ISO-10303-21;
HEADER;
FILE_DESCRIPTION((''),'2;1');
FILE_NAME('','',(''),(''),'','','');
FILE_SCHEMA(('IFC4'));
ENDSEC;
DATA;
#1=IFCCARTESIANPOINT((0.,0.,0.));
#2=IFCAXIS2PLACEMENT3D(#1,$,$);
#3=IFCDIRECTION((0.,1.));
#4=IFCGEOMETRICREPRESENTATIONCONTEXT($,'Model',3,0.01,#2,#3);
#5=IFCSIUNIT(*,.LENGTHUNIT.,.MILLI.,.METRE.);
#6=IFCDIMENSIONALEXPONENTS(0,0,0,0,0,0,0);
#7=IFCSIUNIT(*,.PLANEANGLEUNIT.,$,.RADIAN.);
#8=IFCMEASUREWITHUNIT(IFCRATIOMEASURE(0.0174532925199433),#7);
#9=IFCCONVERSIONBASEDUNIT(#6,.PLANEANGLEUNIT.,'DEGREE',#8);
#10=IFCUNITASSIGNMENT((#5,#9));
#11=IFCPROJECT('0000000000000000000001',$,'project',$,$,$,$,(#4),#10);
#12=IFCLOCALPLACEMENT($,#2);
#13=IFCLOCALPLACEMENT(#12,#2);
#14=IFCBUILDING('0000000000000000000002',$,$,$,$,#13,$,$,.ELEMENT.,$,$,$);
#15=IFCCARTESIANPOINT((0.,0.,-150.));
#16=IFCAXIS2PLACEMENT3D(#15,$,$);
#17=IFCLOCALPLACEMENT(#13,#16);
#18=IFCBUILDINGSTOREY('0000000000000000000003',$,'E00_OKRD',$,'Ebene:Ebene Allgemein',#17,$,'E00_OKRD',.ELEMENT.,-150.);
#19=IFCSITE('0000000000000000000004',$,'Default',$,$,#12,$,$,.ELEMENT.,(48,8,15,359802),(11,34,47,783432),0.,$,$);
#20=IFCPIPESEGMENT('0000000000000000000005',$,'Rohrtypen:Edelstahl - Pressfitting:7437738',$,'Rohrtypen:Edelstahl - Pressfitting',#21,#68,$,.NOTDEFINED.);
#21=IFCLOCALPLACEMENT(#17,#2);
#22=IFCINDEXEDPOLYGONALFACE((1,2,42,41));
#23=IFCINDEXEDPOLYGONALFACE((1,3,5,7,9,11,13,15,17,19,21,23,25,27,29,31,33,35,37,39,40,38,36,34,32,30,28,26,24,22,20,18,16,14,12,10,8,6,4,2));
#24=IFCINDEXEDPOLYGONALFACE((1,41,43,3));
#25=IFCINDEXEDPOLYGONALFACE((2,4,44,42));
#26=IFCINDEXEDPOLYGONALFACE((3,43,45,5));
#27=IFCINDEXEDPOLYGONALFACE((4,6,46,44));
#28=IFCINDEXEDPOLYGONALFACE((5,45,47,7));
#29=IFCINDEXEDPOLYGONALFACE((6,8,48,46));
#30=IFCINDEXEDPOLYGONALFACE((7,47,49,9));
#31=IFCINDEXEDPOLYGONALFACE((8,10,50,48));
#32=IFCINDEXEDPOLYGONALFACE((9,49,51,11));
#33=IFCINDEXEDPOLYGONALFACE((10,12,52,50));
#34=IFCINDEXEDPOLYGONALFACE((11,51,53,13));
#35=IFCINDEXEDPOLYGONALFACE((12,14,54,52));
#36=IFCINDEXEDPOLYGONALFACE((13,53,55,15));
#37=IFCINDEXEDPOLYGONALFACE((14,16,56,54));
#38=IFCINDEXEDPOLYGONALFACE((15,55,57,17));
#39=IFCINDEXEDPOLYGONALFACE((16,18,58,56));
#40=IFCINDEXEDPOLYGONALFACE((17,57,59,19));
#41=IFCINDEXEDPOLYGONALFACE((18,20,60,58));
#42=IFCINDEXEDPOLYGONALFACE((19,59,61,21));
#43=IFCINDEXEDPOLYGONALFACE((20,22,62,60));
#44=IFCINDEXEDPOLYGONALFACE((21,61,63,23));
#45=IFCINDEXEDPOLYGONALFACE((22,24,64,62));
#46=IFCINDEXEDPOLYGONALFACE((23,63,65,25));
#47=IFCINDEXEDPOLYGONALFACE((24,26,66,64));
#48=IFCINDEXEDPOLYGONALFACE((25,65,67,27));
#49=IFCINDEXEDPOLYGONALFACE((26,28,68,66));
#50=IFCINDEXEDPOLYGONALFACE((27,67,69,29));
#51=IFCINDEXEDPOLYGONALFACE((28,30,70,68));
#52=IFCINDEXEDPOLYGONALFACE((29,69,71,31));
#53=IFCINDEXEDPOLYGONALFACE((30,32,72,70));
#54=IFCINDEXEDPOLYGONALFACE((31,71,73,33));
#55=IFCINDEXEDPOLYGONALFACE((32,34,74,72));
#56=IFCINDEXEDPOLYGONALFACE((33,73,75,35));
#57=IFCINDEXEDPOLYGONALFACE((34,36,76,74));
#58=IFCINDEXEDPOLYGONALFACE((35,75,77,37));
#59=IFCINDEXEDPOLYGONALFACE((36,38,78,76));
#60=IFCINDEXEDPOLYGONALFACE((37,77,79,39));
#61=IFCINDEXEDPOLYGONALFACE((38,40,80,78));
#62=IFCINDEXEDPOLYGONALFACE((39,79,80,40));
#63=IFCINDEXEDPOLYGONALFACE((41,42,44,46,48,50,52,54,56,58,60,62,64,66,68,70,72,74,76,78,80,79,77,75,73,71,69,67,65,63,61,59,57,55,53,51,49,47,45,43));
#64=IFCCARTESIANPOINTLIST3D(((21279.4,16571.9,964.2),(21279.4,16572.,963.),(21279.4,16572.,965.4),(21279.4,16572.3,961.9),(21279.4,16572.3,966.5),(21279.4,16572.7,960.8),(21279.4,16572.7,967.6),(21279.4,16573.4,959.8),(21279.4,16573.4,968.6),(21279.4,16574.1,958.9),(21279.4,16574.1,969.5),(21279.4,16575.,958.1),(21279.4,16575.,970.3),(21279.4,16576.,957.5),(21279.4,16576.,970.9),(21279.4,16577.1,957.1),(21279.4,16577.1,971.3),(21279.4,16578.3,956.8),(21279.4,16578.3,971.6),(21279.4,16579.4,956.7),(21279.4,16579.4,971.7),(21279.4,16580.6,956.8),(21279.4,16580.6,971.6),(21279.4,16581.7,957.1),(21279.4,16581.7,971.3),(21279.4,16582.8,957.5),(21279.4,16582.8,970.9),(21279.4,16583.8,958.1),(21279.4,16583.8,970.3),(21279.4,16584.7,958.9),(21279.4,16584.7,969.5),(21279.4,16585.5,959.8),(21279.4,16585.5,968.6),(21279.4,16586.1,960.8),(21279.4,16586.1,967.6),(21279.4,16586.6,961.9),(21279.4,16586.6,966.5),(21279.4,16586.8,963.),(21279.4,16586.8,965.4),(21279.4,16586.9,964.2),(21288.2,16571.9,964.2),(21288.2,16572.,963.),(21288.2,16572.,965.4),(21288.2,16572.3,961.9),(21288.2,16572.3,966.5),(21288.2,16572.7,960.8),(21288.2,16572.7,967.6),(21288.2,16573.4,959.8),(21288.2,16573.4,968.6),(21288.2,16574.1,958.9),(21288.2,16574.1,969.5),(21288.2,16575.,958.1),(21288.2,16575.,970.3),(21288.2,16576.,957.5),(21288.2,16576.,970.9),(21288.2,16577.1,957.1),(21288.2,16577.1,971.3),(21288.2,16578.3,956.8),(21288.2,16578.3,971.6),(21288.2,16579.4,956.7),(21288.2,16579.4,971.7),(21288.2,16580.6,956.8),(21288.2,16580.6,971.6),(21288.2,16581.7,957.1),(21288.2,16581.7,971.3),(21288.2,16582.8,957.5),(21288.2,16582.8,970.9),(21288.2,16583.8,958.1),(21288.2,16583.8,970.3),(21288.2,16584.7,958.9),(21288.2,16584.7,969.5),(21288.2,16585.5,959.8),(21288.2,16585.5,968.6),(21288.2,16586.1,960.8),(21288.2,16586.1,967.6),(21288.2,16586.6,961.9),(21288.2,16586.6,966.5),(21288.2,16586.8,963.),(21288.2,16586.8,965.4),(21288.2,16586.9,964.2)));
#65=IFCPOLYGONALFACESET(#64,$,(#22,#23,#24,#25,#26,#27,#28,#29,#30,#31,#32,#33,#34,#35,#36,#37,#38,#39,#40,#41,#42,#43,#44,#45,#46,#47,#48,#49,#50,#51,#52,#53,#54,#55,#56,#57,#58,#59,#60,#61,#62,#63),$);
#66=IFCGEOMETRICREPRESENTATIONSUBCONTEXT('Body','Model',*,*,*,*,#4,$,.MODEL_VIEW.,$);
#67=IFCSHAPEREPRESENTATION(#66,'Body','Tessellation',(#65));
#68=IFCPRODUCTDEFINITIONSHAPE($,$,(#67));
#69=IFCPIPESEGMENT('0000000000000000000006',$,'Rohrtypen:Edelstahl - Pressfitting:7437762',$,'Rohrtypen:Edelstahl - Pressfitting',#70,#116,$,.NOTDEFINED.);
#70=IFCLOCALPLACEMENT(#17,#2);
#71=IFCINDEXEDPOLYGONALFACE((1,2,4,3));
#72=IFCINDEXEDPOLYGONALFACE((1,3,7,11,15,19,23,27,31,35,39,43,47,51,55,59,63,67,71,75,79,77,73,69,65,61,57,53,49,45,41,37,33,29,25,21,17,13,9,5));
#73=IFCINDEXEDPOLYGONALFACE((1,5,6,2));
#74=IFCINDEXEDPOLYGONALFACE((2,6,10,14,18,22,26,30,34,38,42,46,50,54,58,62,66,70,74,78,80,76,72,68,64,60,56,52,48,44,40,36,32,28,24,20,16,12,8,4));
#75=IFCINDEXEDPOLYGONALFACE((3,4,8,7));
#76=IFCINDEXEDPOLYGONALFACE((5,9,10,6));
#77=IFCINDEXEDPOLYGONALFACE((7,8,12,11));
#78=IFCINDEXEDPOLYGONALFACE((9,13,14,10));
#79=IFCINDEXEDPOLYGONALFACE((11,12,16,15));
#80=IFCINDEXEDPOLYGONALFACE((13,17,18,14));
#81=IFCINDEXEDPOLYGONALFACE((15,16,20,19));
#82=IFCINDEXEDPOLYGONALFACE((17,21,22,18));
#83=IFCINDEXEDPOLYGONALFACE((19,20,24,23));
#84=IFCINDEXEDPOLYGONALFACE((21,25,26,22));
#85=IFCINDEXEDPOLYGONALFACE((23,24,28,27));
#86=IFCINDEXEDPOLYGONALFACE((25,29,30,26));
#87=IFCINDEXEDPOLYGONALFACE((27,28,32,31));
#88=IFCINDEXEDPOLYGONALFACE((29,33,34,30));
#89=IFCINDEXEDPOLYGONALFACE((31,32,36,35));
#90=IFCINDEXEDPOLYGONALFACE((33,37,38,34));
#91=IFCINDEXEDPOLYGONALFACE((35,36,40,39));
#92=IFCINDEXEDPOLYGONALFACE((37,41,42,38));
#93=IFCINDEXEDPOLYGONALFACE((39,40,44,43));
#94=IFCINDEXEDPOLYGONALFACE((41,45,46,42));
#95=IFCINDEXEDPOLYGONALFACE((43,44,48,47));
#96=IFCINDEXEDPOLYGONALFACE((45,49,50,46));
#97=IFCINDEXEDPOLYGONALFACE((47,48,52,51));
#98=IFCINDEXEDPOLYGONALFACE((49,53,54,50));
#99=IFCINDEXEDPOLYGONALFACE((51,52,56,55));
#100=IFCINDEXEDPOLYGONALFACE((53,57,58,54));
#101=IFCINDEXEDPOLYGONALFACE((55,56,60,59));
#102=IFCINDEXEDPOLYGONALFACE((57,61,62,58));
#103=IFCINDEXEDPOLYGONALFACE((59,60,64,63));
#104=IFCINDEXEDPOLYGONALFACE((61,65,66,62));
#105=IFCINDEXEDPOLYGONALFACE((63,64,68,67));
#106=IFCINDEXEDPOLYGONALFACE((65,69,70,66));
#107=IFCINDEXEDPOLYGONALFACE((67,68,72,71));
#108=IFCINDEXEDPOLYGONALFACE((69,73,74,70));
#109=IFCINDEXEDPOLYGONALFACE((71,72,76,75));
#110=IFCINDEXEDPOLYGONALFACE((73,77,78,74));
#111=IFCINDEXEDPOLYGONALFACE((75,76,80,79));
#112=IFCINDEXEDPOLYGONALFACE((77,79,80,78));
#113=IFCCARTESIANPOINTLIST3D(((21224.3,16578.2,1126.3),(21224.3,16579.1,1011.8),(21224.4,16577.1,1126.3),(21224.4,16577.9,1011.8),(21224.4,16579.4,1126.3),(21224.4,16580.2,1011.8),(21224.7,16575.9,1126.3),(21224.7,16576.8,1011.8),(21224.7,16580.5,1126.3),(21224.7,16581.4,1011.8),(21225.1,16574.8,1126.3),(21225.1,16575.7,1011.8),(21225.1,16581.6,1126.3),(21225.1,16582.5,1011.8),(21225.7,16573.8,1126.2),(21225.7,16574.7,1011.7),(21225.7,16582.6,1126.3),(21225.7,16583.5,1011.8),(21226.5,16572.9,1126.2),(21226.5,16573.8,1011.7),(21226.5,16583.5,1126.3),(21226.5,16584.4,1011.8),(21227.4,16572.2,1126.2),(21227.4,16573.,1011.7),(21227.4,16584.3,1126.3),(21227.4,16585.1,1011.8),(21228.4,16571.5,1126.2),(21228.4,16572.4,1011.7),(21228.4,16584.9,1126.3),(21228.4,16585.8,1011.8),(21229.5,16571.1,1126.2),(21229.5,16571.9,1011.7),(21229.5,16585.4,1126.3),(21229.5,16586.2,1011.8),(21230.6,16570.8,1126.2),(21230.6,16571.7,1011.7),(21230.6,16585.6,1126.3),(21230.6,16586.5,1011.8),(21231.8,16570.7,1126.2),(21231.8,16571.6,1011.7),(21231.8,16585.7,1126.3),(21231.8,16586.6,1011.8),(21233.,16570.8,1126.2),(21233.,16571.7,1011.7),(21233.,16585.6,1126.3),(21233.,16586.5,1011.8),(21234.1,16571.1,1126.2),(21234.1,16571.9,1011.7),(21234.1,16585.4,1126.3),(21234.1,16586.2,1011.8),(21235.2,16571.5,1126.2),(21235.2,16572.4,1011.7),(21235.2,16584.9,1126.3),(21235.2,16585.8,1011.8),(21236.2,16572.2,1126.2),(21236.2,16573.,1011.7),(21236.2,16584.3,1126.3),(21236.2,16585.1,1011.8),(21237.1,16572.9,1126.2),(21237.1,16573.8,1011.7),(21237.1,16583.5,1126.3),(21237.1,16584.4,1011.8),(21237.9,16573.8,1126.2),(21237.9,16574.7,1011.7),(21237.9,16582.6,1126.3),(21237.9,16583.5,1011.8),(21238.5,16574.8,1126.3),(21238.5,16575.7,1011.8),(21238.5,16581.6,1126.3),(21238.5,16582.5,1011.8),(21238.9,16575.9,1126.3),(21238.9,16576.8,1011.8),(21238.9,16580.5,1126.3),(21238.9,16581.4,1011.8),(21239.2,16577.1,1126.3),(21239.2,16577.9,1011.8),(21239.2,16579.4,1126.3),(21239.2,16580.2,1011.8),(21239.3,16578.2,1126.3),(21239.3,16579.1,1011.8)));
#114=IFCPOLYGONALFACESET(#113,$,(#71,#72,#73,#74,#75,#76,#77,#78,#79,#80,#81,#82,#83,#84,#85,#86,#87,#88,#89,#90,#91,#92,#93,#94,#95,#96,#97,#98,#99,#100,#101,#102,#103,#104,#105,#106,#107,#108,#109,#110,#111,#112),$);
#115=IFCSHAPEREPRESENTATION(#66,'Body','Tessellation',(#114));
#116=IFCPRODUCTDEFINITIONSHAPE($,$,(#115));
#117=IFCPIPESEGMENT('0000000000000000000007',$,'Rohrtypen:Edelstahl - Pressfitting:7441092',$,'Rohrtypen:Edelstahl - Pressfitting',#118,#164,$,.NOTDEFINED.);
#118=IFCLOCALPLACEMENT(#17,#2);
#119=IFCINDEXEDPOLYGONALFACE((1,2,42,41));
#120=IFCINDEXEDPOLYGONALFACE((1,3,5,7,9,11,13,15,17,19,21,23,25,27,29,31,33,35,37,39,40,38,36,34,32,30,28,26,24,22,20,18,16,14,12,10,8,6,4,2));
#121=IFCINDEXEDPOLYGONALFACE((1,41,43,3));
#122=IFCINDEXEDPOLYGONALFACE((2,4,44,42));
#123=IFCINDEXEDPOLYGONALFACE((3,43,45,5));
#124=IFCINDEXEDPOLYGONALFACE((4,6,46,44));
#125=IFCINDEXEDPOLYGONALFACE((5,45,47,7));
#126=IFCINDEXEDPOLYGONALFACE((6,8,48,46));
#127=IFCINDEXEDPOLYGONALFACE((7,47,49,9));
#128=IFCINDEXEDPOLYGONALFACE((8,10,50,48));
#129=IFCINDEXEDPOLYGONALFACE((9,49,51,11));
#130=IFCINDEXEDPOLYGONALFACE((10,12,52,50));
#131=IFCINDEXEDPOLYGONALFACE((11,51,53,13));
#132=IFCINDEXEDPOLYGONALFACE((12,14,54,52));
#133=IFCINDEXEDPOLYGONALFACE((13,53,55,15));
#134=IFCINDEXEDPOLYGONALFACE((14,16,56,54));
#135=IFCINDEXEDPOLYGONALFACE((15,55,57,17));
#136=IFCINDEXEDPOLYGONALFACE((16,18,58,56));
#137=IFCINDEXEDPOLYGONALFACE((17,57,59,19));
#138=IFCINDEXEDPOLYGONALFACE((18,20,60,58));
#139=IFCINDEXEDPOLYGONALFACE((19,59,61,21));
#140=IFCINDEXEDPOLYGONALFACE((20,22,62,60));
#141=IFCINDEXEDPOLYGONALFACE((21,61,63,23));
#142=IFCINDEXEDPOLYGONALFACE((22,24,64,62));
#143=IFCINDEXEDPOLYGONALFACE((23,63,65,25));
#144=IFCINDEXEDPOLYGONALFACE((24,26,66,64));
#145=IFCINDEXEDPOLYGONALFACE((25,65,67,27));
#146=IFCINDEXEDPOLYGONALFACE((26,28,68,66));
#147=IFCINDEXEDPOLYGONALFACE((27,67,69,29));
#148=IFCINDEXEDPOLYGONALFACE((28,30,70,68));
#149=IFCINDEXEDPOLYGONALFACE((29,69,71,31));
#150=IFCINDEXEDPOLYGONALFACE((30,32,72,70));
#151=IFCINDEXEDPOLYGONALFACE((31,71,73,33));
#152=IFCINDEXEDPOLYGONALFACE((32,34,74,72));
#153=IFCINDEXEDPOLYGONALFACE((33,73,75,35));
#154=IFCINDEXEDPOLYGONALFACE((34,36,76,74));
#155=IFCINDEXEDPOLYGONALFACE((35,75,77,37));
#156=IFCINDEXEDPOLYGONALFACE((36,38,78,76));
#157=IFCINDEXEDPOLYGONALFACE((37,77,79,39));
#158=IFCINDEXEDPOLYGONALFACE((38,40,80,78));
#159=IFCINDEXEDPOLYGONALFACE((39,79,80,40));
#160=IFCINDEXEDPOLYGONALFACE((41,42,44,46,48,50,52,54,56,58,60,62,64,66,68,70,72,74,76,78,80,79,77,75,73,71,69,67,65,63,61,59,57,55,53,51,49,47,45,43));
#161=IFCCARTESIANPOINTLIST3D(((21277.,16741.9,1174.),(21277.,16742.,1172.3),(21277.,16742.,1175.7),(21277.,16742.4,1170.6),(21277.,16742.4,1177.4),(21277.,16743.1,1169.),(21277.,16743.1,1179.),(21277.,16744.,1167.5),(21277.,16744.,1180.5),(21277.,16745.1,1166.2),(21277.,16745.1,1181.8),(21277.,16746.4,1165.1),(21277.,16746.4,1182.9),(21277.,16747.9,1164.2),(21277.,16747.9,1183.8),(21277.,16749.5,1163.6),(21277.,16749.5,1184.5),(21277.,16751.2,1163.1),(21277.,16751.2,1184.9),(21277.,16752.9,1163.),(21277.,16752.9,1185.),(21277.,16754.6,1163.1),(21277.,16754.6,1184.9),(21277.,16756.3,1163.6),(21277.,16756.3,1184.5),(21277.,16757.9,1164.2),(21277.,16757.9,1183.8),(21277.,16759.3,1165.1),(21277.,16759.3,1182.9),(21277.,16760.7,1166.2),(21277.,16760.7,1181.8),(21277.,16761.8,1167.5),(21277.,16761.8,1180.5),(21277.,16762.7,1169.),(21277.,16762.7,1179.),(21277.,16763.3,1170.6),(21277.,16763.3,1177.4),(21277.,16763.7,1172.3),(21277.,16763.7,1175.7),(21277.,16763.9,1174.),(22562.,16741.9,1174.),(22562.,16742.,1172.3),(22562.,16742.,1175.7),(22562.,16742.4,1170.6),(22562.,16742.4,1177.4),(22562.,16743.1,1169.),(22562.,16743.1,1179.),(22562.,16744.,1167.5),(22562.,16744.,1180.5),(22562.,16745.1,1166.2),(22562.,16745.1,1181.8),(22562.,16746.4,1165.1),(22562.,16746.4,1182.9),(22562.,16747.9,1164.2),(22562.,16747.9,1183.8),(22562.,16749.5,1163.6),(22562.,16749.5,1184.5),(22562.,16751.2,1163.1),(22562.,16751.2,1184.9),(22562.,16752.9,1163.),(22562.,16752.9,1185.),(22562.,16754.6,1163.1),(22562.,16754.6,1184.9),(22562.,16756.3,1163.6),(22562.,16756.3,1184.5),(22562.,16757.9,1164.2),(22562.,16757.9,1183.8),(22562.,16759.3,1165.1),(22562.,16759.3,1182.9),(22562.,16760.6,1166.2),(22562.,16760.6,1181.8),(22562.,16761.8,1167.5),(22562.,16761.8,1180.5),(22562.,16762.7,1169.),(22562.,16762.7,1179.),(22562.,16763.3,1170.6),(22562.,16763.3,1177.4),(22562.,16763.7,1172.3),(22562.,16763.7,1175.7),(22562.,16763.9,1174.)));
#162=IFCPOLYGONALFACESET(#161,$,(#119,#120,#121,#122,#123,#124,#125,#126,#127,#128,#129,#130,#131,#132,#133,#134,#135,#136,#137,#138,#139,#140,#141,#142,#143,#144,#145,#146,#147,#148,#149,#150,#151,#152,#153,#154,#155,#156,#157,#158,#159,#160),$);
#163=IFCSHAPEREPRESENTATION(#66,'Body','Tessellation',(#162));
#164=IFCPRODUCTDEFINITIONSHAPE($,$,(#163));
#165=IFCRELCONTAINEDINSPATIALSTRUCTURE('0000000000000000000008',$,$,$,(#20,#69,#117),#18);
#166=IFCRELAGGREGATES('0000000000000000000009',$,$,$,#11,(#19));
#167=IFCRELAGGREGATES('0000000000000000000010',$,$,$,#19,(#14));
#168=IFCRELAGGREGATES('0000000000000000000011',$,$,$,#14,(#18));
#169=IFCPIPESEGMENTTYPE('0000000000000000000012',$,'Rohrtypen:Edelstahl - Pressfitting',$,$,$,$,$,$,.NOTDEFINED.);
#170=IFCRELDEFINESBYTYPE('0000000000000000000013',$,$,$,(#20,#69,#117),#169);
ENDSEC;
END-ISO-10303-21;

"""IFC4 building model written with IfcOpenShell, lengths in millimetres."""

from ifc_helpers import new_model, entity, si_unit, converted_unit, direction, frame, origin, place, context, subcontext, project, spatial, indexed_curve, outline, extrude, type_object, element, save


model = new_model("IFC4")

# Units and contexts
model_context = context("Model", 3, precision=0.01, world=origin(), true_north=direction((0.0, 1.0)))
body_context = subcontext(model_context, "Body", "Model", "MODEL_VIEW")
ifc_project = project(units=[si_unit("LENGTHUNIT", "METRE", prefix="MILLI"), converted_unit("PLANEANGLEUNIT", "DEGREE", entity("IfcRatioMeasure", 0.0174532925199433), si_unit("PLANEANGLEUNIT", "RADIAN"), dimensions=[0, 0, 0, 0, 0, 0, 0])], contexts=[model_context])

# Site, building, storey
site_placement = place(None, origin())
site = spatial("IfcSite", under=ifc_project, at=site_placement, Name="Default", CompositionType="ELEMENT", RefLatitude=(48, 8, 15, 359802), RefLongitude=(11, 34, 47, 783432), RefElevation=0.0)
building_placement = place(site_placement, origin())
building = spatial("IfcBuilding", under=site, at=building_placement, CompositionType="ELEMENT")
storey_placement = place(building_placement, frame((0.0, 0.0, -150.0)))
storey = spatial("IfcBuildingStorey", under=building, at=storey_placement, Name="E00_OKRD", ObjectType="Ebene:Ebene Allgemein", LongName="E00_OKRD", CompositionType="ELEMENT", Elevation=-150.0)

# Pipe segments
pipe_segment_type_1 = type_object("IfcPipeSegmentType", Name="Rohrtypen:Edelstahl - Pressfitting", PredefinedType="NOTDEFINED")
pipe_segment_1_placement = place(storey_placement, origin())
element("IfcPipeSegment", 1, at=pipe_segment_1_placement, inside=storey, type_object=pipe_segment_type_1, Name="Rohrtypen:Edelstahl - Pressfitting:7437738", ObjectType="Rohrtypen:Edelstahl - Pressfitting", PredefinedType="NOTDEFINED", context=body_context, shape_type="SweptSolid", body=[
    extrude(outline(indexed_curve([(7.5, 0.0), (7.4, 1.2), (7.1, 2.3), (6.7, 3.4), (6.1, 4.4), (5.3, 5.3), (4.4, 6.1), (3.4, 6.7), (2.3, 7.1), (1.2, 7.4), (0.0, 7.5), (-1.2, 7.4), (-2.3, 7.1), (-3.4, 6.7), (-4.4, 6.1), (-5.3, 5.3), (-6.1, 4.4), (-6.7, 3.4), (-7.1, 2.3), (-7.4, 1.2), (-7.5, 0.0), (-7.4, -1.2), (-7.1, -2.3), (-6.7, -3.4), (-6.1, -4.4), (-5.3, -5.3), (-4.4, -6.1), (-3.4, -6.7), (-2.3, -7.1), (-1.2, -7.4), (0.0, -7.5), (1.2, -7.4), (2.3, -7.1), (3.4, -6.7), (4.4, -6.1), (5.3, -5.3), (6.1, -4.4), (6.7, -3.4), (7.1, -2.3), (7.4, -1.2), (7.5, 0.0)], self_intersect=False)), frame((21279.4, 16579.4, 964.2), z_axis=(1.0, 0.000009, 0.0), x_axis=(-0.000009, 1.0, 0.0)), (0.0, 0.0, 1.0), 8.8),
])
pipe_segment_2_placement = place(storey_placement, origin())
element("IfcPipeSegment", 2, at=pipe_segment_2_placement, inside=storey, type_object=pipe_segment_type_1, Name="Rohrtypen:Edelstahl - Pressfitting:7437762", ObjectType="Rohrtypen:Edelstahl - Pressfitting", PredefinedType="NOTDEFINED", context=body_context, shape_type="SweptSolid", body=[
    extrude(outline(indexed_curve([(7.5, 0.0), (7.4, 1.2), (7.1, 2.3), (6.7, 3.4), (6.1, 4.4), (5.3, 5.3), (4.4, 6.1), (3.4, 6.7), (2.3, 7.1), (1.2, 7.4), (0.0, 7.5), (-1.2, 7.4), (-2.3, 7.1), (-3.4, 6.7), (-4.4, 6.1), (-5.3, 5.3), (-6.1, 4.4), (-6.7, 3.4), (-7.1, 2.3), (-7.4, 1.2), (-7.5, 0.0), (-7.4, -1.2), (-7.1, -2.3), (-6.7, -3.4), (-6.1, -4.4), (-5.3, -5.3), (-4.4, -6.1), (-3.4, -6.7), (-2.3, -7.1), (-1.2, -7.4), (0.0, -7.5), (1.2, -7.4), (2.3, -7.1), (3.4, -6.7), (4.4, -6.1), (5.3, -5.3), (6.1, -4.4), (6.7, -3.4), (7.1, -2.3), (7.4, -1.2), (7.5, 0.0)], self_intersect=False)), frame((21231.8, 16578.2, 1126.3), z_axis=(0.0, 0.007379, -0.999973), x_axis=(-1.0, 0.0, 0.0)), (0.0, 0.0, 1.0), 114.5),
])
pipe_segment_3_placement = place(storey_placement, origin())
element("IfcPipeSegment", 3, at=pipe_segment_3_placement, inside=storey, type_object=pipe_segment_type_1, Name="Rohrtypen:Edelstahl - Pressfitting:7441092", ObjectType="Rohrtypen:Edelstahl - Pressfitting", PredefinedType="NOTDEFINED", context=body_context, shape_type="SweptSolid", body=[
    extrude(outline(indexed_curve([(11.0, 0.0), (10.9, 1.7), (10.5, 3.4), (9.8, 5.0), (8.9, 6.5), (7.8, 7.8), (6.5, 8.9), (5.0, 9.8), (3.4, 10.5), (1.7, 10.9), (0.0, 11.0), (-1.7, 10.9), (-3.4, 10.5), (-5.0, 9.8), (-6.5, 8.9), (-7.8, 7.8), (-8.9, 6.5), (-9.8, 5.0), (-10.5, 3.4), (-10.9, 1.7), (-11.0, 0.0), (-10.9, -1.7), (-10.5, -3.4), (-9.8, -5.0), (-8.9, -6.5), (-7.8, -7.8), (-6.5, -8.9), (-5.0, -9.8), (-3.4, -10.5), (-1.7, -10.9), (0.0, -11.0), (1.7, -10.9), (3.4, -10.5), (5.0, -9.8), (6.5, -8.9), (7.8, -7.8), (8.9, -6.5), (9.8, -5.0), (10.5, -3.4), (10.9, -1.7), (11.0, 0.0)], self_intersect=False)), frame((21277.0, 16752.9, 1174.0), z_axis=(1.0, -0.000001, 0.0), x_axis=(-0.000001, -1.0, 0.0)), (0.0, 0.0, 1.0), 1285.0),
])

save(model, "model.ifc")
